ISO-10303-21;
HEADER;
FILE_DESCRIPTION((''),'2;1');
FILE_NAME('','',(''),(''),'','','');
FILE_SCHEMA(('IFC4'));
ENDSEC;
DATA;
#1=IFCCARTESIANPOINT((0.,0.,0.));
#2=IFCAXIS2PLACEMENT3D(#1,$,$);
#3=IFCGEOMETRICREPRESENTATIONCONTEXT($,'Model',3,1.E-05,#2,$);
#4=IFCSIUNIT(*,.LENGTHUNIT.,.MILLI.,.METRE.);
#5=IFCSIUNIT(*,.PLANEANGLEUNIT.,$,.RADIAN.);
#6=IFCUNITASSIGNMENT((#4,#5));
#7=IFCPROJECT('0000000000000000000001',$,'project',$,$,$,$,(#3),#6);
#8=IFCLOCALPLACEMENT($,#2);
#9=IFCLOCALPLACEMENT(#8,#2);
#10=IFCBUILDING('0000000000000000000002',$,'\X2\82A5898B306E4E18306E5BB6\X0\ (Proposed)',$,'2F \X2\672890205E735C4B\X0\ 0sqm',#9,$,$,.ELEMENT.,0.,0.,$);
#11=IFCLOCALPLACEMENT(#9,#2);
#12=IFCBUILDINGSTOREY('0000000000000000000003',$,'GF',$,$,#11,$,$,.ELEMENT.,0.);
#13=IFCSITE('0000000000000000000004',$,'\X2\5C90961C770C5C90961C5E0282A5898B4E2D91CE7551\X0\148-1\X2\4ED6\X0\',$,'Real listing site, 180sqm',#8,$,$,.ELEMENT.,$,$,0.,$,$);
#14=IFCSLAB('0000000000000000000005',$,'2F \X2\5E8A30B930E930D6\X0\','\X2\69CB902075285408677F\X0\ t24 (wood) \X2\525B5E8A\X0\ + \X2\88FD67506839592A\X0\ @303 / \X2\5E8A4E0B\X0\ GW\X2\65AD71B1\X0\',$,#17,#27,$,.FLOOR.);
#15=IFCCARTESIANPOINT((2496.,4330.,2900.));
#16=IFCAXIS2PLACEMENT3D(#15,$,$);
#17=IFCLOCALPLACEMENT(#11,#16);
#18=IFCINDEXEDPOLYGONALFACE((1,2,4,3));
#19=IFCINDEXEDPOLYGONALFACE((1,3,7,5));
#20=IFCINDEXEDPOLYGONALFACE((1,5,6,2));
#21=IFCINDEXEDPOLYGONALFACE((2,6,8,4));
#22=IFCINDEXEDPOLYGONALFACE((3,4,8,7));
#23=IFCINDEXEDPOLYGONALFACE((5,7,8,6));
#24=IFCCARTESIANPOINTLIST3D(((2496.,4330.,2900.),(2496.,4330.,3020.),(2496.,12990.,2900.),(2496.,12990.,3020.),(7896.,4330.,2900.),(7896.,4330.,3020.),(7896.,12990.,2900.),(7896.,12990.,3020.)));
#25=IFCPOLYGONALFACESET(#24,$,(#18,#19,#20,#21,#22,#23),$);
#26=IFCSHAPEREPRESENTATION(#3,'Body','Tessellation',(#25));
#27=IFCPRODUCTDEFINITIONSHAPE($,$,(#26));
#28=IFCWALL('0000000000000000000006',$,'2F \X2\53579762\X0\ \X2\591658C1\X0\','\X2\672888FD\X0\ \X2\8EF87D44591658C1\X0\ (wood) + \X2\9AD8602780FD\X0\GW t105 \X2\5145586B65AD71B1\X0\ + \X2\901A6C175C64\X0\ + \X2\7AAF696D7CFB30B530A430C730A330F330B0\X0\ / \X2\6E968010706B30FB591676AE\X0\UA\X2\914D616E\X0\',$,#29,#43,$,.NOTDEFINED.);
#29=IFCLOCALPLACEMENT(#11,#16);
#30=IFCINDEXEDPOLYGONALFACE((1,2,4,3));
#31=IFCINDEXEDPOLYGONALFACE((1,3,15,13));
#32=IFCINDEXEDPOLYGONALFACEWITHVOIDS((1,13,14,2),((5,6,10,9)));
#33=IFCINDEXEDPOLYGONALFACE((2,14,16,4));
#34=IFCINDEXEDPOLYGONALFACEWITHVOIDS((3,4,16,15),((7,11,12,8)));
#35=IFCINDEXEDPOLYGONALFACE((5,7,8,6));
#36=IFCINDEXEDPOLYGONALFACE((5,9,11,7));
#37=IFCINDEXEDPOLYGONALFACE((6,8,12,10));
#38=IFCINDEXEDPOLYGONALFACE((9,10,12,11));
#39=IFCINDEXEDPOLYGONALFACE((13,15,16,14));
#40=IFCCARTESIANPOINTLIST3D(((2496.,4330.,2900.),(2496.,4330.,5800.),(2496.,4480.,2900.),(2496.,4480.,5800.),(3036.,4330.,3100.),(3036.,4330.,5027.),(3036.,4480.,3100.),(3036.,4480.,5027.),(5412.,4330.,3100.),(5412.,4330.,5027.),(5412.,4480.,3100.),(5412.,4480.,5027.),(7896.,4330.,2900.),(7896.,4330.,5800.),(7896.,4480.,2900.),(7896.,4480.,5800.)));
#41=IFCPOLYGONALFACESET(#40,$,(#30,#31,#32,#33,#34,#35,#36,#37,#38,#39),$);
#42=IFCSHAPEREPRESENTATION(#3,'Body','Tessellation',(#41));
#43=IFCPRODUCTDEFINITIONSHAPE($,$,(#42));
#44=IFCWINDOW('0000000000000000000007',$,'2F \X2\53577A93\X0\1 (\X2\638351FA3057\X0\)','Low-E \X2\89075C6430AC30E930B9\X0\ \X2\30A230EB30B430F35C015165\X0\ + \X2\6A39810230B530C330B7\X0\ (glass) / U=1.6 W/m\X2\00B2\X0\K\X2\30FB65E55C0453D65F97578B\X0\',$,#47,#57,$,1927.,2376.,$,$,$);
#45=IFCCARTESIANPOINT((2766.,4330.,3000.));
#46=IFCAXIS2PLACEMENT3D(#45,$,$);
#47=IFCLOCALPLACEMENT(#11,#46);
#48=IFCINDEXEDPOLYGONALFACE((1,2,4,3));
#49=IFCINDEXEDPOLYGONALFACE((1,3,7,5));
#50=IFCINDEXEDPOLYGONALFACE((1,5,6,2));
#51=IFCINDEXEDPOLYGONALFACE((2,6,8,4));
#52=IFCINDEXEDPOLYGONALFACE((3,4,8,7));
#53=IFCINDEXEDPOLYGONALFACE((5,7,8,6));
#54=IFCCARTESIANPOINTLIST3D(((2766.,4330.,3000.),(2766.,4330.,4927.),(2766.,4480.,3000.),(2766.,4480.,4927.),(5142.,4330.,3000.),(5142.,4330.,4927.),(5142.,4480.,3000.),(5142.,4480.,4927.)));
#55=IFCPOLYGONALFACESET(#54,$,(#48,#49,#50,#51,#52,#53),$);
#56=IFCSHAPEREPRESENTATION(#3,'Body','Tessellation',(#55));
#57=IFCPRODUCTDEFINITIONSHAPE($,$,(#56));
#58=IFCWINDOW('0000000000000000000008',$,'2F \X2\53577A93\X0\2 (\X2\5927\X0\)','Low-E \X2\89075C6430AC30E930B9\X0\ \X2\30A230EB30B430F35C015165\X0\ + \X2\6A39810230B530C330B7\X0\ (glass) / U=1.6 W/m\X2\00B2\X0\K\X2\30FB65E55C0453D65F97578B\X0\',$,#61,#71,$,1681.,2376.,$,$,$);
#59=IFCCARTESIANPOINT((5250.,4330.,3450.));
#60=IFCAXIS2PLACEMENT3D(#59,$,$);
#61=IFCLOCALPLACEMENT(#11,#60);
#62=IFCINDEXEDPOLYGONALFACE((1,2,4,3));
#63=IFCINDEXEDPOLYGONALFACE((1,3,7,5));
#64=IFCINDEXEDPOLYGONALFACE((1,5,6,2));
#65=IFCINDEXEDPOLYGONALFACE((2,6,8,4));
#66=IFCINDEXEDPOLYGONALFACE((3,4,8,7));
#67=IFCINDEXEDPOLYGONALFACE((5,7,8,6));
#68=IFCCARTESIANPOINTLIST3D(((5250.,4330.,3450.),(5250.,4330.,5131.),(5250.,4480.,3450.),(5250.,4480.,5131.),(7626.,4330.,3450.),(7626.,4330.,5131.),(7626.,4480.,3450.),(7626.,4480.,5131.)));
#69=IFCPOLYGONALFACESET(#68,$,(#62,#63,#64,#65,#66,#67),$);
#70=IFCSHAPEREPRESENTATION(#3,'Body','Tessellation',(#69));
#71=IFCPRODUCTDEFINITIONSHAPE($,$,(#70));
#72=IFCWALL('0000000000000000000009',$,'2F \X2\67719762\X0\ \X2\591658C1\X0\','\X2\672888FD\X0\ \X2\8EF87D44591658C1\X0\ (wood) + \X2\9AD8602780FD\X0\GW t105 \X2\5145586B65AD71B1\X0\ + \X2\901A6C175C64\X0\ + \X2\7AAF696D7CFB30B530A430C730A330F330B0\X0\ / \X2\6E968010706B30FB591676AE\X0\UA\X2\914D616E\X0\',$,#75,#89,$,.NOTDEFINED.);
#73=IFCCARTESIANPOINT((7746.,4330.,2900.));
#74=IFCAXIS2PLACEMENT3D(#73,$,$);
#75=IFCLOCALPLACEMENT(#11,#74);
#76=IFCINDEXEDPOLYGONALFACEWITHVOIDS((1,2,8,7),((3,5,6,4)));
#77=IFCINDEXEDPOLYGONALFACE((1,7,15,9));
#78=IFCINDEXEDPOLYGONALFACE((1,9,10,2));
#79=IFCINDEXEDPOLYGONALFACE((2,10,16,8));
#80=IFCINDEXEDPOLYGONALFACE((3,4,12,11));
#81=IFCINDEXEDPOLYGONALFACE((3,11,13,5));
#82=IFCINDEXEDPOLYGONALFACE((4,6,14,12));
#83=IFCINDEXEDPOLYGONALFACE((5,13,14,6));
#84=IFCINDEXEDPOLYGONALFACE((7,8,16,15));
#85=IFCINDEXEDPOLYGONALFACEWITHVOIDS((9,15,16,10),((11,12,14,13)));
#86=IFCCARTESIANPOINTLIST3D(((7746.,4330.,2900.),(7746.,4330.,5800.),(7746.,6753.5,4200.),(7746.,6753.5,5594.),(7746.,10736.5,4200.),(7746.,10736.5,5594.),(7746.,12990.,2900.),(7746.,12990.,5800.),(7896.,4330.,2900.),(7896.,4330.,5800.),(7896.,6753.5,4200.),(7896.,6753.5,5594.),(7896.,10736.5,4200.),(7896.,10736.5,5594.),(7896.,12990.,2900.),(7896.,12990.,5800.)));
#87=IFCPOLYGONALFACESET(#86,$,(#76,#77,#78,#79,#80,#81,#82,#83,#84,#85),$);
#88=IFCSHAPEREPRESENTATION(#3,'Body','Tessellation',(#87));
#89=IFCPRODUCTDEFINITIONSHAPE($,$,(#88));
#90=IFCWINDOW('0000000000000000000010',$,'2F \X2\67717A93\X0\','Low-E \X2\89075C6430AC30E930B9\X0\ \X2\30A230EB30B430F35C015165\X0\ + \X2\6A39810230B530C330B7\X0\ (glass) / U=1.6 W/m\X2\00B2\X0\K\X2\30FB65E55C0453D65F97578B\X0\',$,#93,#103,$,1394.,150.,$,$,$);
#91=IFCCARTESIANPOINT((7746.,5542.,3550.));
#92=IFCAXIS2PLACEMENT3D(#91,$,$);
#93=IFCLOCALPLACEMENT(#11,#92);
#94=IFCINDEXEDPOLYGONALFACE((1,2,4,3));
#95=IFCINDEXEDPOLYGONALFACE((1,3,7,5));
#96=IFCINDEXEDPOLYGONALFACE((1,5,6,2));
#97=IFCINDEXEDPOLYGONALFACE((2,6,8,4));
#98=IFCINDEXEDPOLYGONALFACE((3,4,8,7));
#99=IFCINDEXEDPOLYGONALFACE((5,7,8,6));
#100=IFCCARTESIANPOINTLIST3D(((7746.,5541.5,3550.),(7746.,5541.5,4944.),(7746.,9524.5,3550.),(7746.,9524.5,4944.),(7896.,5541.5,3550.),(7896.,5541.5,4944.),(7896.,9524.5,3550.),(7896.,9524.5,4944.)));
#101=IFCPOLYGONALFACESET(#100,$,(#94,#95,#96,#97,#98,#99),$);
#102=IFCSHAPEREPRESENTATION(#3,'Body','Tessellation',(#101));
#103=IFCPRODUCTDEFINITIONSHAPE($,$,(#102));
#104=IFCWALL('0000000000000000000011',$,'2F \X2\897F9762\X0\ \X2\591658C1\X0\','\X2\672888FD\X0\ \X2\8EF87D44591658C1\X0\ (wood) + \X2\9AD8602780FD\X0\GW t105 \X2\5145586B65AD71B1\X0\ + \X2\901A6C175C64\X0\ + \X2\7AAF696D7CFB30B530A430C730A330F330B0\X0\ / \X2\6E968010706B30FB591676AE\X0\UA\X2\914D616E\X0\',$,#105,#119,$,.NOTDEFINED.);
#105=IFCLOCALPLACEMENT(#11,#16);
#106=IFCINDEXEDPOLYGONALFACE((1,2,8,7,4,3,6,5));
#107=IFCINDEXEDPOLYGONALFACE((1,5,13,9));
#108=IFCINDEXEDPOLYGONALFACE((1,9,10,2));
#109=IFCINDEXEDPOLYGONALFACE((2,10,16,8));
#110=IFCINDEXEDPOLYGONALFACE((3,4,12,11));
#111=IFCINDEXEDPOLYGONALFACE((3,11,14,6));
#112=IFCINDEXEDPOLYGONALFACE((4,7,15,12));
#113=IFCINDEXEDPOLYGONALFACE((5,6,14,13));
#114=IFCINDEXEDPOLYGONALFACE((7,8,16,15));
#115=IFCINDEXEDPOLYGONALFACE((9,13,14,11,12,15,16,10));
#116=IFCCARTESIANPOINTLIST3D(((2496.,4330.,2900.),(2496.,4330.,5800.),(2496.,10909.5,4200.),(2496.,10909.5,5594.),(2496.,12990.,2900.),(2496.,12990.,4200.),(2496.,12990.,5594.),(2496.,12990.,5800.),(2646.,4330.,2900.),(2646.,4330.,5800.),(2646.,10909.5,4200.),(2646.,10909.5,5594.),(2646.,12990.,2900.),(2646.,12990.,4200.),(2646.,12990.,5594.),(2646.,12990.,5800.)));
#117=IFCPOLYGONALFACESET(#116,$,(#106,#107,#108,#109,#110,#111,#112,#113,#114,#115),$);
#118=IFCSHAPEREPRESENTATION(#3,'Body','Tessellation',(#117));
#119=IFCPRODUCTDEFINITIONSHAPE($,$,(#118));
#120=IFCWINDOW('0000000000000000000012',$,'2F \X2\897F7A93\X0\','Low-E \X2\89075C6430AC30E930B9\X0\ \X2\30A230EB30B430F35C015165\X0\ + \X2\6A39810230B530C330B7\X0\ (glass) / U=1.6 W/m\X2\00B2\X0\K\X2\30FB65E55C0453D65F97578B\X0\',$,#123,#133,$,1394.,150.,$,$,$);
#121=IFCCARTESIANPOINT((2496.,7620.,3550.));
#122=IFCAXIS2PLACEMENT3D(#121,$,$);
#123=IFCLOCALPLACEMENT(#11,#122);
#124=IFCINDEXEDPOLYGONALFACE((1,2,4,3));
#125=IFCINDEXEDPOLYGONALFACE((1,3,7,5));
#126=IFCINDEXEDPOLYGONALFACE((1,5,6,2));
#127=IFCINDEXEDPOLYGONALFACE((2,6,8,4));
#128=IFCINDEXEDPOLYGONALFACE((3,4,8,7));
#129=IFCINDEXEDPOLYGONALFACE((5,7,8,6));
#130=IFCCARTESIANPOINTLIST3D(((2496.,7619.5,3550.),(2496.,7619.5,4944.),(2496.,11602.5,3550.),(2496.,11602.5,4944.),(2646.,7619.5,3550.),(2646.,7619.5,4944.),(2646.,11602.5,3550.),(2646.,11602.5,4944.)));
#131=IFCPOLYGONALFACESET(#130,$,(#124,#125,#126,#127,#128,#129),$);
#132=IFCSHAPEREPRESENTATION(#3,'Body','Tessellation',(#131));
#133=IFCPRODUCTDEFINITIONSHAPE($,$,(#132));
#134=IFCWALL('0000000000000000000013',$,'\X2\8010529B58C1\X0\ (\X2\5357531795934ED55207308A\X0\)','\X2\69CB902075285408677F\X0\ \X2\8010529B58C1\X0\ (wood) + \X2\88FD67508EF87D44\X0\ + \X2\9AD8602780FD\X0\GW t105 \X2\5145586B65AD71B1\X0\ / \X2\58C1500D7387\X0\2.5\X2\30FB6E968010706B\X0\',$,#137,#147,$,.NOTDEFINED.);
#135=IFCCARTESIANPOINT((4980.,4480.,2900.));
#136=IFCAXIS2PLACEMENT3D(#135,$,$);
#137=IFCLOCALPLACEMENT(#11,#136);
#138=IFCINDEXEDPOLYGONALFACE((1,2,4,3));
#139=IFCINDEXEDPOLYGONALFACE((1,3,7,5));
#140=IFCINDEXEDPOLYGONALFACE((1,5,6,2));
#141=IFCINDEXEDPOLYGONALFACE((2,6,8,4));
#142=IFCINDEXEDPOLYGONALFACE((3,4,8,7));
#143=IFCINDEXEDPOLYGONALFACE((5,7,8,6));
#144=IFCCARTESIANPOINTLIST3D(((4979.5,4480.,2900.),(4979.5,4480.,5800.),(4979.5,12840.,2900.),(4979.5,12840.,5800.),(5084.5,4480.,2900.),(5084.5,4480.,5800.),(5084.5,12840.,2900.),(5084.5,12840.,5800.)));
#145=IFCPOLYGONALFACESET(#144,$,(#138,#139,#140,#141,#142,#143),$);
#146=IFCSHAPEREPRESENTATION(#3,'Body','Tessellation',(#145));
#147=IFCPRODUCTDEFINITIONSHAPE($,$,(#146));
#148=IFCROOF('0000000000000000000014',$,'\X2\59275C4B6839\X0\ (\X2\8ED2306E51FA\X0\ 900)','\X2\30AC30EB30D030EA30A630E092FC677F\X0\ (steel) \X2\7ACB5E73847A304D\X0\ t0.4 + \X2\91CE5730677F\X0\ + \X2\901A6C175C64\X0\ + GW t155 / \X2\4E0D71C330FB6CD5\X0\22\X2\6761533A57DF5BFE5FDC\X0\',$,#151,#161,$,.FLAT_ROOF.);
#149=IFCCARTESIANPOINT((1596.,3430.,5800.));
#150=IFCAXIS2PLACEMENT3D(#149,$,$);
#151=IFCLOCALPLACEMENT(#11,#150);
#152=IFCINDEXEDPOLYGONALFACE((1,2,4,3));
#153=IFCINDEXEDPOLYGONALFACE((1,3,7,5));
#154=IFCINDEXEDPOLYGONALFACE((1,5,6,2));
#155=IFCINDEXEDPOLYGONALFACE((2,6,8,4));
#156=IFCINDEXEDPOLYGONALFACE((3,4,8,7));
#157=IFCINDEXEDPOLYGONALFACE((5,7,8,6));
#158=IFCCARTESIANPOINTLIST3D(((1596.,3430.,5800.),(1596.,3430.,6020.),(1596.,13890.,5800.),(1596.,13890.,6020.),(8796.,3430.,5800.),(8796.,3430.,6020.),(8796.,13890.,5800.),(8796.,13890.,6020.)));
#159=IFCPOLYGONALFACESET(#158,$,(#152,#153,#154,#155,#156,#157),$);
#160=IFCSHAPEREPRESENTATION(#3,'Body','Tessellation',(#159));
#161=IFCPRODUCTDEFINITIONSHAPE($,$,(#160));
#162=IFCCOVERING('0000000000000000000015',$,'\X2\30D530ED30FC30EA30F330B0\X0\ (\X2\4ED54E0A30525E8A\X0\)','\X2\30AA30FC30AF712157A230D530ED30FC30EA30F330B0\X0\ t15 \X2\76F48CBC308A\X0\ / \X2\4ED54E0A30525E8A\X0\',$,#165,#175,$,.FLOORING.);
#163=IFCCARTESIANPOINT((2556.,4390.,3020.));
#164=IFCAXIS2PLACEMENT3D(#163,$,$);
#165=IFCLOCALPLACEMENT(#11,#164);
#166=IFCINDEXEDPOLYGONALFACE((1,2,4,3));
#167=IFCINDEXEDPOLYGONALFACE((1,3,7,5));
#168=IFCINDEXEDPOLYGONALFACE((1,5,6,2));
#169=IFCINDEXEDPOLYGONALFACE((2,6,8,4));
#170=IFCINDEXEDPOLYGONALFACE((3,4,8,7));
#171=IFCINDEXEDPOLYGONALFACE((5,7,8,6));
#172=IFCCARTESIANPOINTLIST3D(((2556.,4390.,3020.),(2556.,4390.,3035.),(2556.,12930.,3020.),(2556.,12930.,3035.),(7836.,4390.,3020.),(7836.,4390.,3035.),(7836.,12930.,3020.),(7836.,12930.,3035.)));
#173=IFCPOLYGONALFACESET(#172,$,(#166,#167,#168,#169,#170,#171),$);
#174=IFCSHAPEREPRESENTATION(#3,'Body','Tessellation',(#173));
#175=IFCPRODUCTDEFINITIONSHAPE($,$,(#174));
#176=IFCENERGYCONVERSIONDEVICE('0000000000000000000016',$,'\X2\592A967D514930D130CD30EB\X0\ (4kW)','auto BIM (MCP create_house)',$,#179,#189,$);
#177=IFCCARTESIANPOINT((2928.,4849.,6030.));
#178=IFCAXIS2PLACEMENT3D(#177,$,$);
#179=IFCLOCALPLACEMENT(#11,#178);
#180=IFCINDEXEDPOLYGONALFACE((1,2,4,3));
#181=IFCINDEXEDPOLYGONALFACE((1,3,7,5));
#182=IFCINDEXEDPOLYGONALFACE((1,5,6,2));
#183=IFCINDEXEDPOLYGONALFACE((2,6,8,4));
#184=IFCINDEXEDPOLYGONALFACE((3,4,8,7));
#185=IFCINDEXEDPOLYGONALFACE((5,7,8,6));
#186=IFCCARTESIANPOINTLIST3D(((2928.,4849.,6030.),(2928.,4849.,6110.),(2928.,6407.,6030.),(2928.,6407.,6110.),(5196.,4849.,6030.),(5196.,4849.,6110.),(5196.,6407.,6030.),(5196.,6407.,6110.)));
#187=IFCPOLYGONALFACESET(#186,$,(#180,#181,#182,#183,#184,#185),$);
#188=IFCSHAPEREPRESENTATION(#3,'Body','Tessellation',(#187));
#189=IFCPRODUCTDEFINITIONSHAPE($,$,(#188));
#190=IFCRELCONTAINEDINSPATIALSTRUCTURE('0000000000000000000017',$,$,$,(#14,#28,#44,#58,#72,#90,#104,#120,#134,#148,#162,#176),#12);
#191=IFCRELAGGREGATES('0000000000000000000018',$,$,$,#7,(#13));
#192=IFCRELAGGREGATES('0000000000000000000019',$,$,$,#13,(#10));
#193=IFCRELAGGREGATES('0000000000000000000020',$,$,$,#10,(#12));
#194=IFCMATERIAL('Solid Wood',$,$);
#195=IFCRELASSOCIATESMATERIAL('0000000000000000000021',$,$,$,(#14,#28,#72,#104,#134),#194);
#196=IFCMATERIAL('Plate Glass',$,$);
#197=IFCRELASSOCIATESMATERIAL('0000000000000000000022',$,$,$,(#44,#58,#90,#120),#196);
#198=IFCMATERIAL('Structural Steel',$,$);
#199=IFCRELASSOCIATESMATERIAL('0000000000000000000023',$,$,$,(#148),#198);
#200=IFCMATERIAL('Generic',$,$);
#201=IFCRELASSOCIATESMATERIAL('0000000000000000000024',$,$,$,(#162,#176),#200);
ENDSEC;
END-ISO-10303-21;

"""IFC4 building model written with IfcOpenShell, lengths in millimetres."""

from ifc_helpers import new_model, si_unit, frame, frame_2d, origin, place, context, project, spatial, rectangle, extrude, material, element, fill, save


model = new_model("IFC4")

# Units and contexts
model_context = context("Model", 3, precision=1e-05, world=origin())
ifc_project = project(units=[si_unit("LENGTHUNIT", "METRE", prefix="MILLI"), si_unit("PLANEANGLEUNIT", "RADIAN")], contexts=[model_context])

# Site, building, storey
site_placement = place(None, origin())
site = spatial("IfcSite", under=ifc_project, at=site_placement, Name="岐阜県岐阜市芥見中野畑148-1他", ObjectType="Real listing site, 180sqm", CompositionType="ELEMENT", RefElevation=0.0)
building_placement = place(site_placement, origin())
building = spatial("IfcBuilding", under=site, at=building_placement, Name="芥見の丘の家 (Proposed)", ObjectType="2F 木造平屋 0sqm", CompositionType="ELEMENT", ElevationOfRefHeight=0.0, ElevationOfTerrain=0.0)
storey_placement = place(building_placement, origin())
storey = spatial("IfcBuildingStorey", under=building, at=storey_placement, Name="GF", CompositionType="ELEMENT", Elevation=0.0)

# Slab
ifc_material_1 = material(Name="Solid Wood")
slab_placement = place(storey_placement, frame((2496.0, 4330.0, 2900.0)))
element("IfcSlab", 1, at=slab_placement, inside=storey, material=ifc_material_1, Name="2F 床スラブ", Description="構造用合板 t24 (wood) 剛床 + 製材根太 @303 / 床下 GW断熱", PredefinedType="FLOOR", context=model_context, shape_type="SweptSolid", body=[
    extrude(rectangle(XDim=5400.0, YDim=8660.0, at=frame_2d((2700.0, 4330.0))), frame((2496.0, 4330.0, 2900.0)), (0.0, 0.0, 1.0), 120.0),
])

# Wall, openings, windows
wall_1_placement = place(storey_placement, frame((2496.0, 4330.0, 2900.0)))
wall_1 = element("IfcWall", 2, at=wall_1_placement, inside=storey, material=ifc_material_1, Name="2F 南面 外壁", Description="木製 軸組外壁 (wood) + 高性能GW t105 充填断熱 + 通気層 + 窯業系サイディング / 準耐火・外皮UA配慮", PredefinedType="NOTDEFINED", context=model_context, shape_type="SweptSolid", body=[
    extrude(rectangle(XDim=5400.0, YDim=150.0, at=frame_2d((2700.0, 75.0))), frame((2496.0, 4330.0, 2900.0)), (0.0, 0.0, 1.0), 2900.0),
])
opening_1_placement = place(storey_placement, frame((2766.0, 4330.0, 3000.0)))
opening_1 = element("IfcOpeningElement", 3, at=opening_1_placement, cuts=wall_1, PredefinedType="NOTDEFINED", context=model_context, shape_type="SweptSolid", body=[
    extrude(rectangle(XDim=2376.0, YDim=150.0, at=frame_2d((1188.0, 75.0))), frame((2766.0, 4330.0, 3000.0)), (0.0, 0.0, 1.0), 1927.0),
])
opening_2_placement = place(storey_placement, frame((5250.0, 4330.0, 3450.0)))
opening_2 = element("IfcOpeningElement", 4, at=opening_2_placement, cuts=wall_1, PredefinedType="NOTDEFINED", context=model_context, shape_type="SweptSolid", body=[
    extrude(rectangle(XDim=2376.0, YDim=150.0, at=frame_2d((1188.0, 75.0))), frame((5250.0, 4330.0, 3450.0)), (0.0, 0.0, 1.0), 1681.0),
])
ifc_material_2 = material(Name="Plate Glass")
window_1_placement = place(storey_placement, frame((2766.0, 4330.0, 3000.0)))
window_1 = element("IfcWindow", 5, at=window_1_placement, inside=storey, material=ifc_material_2, Name="2F 南窓1 (掃出し)", Description="Low-E 複層ガラス アルゴン封入 + 樹脂サッシ (glass) / U=1.6 W/m²K・日射取得型", OverallHeight=1927.0, OverallWidth=2376.0, context=model_context, shape_type="SweptSolid", body=[
    extrude(rectangle(XDim=2376.0, YDim=150.0, at=frame_2d((1188.0, 75.0))), frame((2766.0, 4330.0, 3000.0)), (0.0, 0.0, 1.0), 1927.0),
])
fill(opening_1, window_1)
window_2_placement = place(storey_placement, frame((5250.0, 4330.0, 3450.0)))
window_2 = element("IfcWindow", 6, at=window_2_placement, inside=storey, material=ifc_material_2, Name="2F 南窓2 (大)", Description="Low-E 複層ガラス アルゴン封入 + 樹脂サッシ (glass) / U=1.6 W/m²K・日射取得型", OverallHeight=1681.0, OverallWidth=2376.0, context=model_context, shape_type="SweptSolid", body=[
    extrude(rectangle(XDim=2376.0, YDim=150.0, at=frame_2d((1188.0, 75.0))), frame((5250.0, 4330.0, 3450.0)), (0.0, 0.0, 1.0), 1681.0),
])
fill(opening_2, window_2)

# Walls, openings, windows
wall_2_placement = place(storey_placement, frame((7746.0, 4330.0, 2900.0)))
wall_2 = element("IfcWall", 7, at=wall_2_placement, inside=storey, material=ifc_material_1, Name="2F 東面 外壁", Description="木製 軸組外壁 (wood) + 高性能GW t105 充填断熱 + 通気層 + 窯業系サイディング / 準耐火・外皮UA配慮", PredefinedType="NOTDEFINED", context=model_context, shape_type="SweptSolid", body=[
    extrude(rectangle(XDim=150.0, YDim=8660.0, at=frame_2d((75.0, 4330.0))), frame((7746.0, 4330.0, 2900.0)), (0.0, 0.0, 1.0), 2900.0),
])
opening_3_placement = place(storey_placement, frame((7746.0, 5542.0, 3550.0)))
opening_3 = element("IfcOpeningElement", 8, at=opening_3_placement, cuts=wall_2, PredefinedType="NOTDEFINED", context=model_context, shape_type="SweptSolid", body=[
    extrude(rectangle(XDim=150.0, YDim=3983.0, at=frame_2d((75.0, 1991.0))), frame((7746.0, 5542.0, 3550.0)), (0.0, 0.0, 1.0), 1394.0),
])
window_3_placement = place(storey_placement, frame((7746.0, 5542.0, 3550.0)))
window_3 = element("IfcWindow", 9, at=window_3_placement, inside=storey, material=ifc_material_2, Name="2F 東窓", Description="Low-E 複層ガラス アルゴン封入 + 樹脂サッシ (glass) / U=1.6 W/m²K・日射取得型", OverallHeight=1394.0, OverallWidth=150.0, context=model_context, shape_type="SweptSolid", body=[
    extrude(rectangle(XDim=150.0, YDim=3983.0, at=frame_2d((75.0, 1991.0))), frame((7746.0, 5542.0, 3550.0)), (0.0, 0.0, 1.0), 1394.0),
])
fill(opening_3, window_3)
wall_3_placement = place(storey_placement, frame((2496.0, 4330.0, 2900.0)))
wall_3 = element("IfcWall", 10, at=wall_3_placement, inside=storey, material=ifc_material_1, Name="2F 西面 外壁", Description="木製 軸組外壁 (wood) + 高性能GW t105 充填断熱 + 通気層 + 窯業系サイディング / 準耐火・外皮UA配慮", PredefinedType="NOTDEFINED", context=model_context, shape_type="SweptSolid", body=[
    extrude(rectangle(XDim=150.0, YDim=8660.0, at=frame_2d((75.0, 4330.0))), frame((2496.0, 4330.0, 2900.0)), (0.0, 0.0, 1.0), 2900.0),
])
opening_4_placement = place(storey_placement, frame((2496.0, 7620.0, 3550.0)))
opening_4 = element("IfcOpeningElement", 11, at=opening_4_placement, cuts=wall_3, PredefinedType="NOTDEFINED", context=model_context, shape_type="SweptSolid", body=[
    extrude(rectangle(XDim=150.0, YDim=3983.0, at=frame_2d((75.0, 1991.0))), frame((2496.0, 7620.0, 3550.0)), (0.0, 0.0, 1.0), 1394.0),
])
window_4_placement = place(storey_placement, frame((2496.0, 7620.0, 3550.0)))
window_4 = element("IfcWindow", 12, at=window_4_placement, inside=storey, material=ifc_material_2, Name="2F 西窓", Description="Low-E 複層ガラス アルゴン封入 + 樹脂サッシ (glass) / U=1.6 W/m²K・日射取得型", OverallHeight=1394.0, OverallWidth=150.0, context=model_context, shape_type="SweptSolid", body=[
    extrude(rectangle(XDim=150.0, YDim=3983.0, at=frame_2d((75.0, 1991.0))), frame((2496.0, 7620.0, 3550.0)), (0.0, 0.0, 1.0), 1394.0),
])
fill(opening_4, window_4)

# Wall
wall_4_placement = place(storey_placement, frame((4980.0, 4480.0, 2900.0)))
element("IfcWall", 13, at=wall_4_placement, inside=storey, material=ifc_material_1, Name="耐力壁 (南北間仕切り)", Description="構造用合板 耐力壁 (wood) + 製材軸組 + 高性能GW t105 充填断熱 / 壁倍率2.5・準耐火", PredefinedType="NOTDEFINED", context=model_context, shape_type="SweptSolid", body=[
    extrude(rectangle(XDim=105.0, YDim=8360.0, at=frame_2d((52.0, 4180.0))), frame((4980.0, 4480.0, 2900.0)), (0.0, 0.0, 1.0), 2900.0),
])

# Roof
ifc_material_3 = material(Name="Structural Steel")
roof_placement = place(storey_placement, frame((1596.0, 3430.0, 5800.0)))
element("IfcRoof", 14, at=roof_placement, inside=storey, material=ifc_material_3, Name="大屋根 (軒の出 900)", Description="ガルバリウム鋼板 (steel) 立平葺き t0.4 + 野地板 + 通気層 + GW t155 / 不燃・法22条区域対応", PredefinedType="FLAT_ROOF", context=model_context, shape_type="SweptSolid", body=[
    extrude(rectangle(XDim=7200.0, YDim=10460.0, at=frame_2d((3600.0, 5230.0))), frame((1596.0, 3430.0, 5800.0)), (0.0, 0.0, 1.0), 220.0),
])

# Covering
ifc_material_4 = material(Name="Generic")
covering_placement = place(storey_placement, frame((2556.0, 4390.0, 3020.0)))
element("IfcCovering", 15, at=covering_placement, inside=storey, material=ifc_material_4, Name="フローリング (仕上げ床)", Description="オーク無垢フローリング t15 直貼り / 仕上げ床", PredefinedType="FLOORING", context=model_context, shape_type="SweptSolid", body=[
    extrude(rectangle(XDim=5280.0, YDim=8540.0, at=frame_2d((2640.0, 4270.0))), frame((2556.0, 4390.0, 3020.0)), (0.0, 0.0, 1.0), 15.0),
])

# Energy conversion device
energy_conversion_device_placement = place(storey_placement, frame((2928.0, 4849.0, 6030.0)))
element("IfcEnergyConversionDevice", 16, at=energy_conversion_device_placement, inside=storey, material=ifc_material_4, Name="太陽光パネル (4kW)", Description="auto BIM (MCP create_house)", context=model_context, shape_type="SweptSolid", body=[
    extrude(rectangle(XDim=2268.0, YDim=1558.0, at=frame_2d((1134.0, 779.0))), frame((2928.0, 4849.0, 6030.0)), (0.0, 0.0, 1.0), 80.0),
])

save(model, "model.ifc")
